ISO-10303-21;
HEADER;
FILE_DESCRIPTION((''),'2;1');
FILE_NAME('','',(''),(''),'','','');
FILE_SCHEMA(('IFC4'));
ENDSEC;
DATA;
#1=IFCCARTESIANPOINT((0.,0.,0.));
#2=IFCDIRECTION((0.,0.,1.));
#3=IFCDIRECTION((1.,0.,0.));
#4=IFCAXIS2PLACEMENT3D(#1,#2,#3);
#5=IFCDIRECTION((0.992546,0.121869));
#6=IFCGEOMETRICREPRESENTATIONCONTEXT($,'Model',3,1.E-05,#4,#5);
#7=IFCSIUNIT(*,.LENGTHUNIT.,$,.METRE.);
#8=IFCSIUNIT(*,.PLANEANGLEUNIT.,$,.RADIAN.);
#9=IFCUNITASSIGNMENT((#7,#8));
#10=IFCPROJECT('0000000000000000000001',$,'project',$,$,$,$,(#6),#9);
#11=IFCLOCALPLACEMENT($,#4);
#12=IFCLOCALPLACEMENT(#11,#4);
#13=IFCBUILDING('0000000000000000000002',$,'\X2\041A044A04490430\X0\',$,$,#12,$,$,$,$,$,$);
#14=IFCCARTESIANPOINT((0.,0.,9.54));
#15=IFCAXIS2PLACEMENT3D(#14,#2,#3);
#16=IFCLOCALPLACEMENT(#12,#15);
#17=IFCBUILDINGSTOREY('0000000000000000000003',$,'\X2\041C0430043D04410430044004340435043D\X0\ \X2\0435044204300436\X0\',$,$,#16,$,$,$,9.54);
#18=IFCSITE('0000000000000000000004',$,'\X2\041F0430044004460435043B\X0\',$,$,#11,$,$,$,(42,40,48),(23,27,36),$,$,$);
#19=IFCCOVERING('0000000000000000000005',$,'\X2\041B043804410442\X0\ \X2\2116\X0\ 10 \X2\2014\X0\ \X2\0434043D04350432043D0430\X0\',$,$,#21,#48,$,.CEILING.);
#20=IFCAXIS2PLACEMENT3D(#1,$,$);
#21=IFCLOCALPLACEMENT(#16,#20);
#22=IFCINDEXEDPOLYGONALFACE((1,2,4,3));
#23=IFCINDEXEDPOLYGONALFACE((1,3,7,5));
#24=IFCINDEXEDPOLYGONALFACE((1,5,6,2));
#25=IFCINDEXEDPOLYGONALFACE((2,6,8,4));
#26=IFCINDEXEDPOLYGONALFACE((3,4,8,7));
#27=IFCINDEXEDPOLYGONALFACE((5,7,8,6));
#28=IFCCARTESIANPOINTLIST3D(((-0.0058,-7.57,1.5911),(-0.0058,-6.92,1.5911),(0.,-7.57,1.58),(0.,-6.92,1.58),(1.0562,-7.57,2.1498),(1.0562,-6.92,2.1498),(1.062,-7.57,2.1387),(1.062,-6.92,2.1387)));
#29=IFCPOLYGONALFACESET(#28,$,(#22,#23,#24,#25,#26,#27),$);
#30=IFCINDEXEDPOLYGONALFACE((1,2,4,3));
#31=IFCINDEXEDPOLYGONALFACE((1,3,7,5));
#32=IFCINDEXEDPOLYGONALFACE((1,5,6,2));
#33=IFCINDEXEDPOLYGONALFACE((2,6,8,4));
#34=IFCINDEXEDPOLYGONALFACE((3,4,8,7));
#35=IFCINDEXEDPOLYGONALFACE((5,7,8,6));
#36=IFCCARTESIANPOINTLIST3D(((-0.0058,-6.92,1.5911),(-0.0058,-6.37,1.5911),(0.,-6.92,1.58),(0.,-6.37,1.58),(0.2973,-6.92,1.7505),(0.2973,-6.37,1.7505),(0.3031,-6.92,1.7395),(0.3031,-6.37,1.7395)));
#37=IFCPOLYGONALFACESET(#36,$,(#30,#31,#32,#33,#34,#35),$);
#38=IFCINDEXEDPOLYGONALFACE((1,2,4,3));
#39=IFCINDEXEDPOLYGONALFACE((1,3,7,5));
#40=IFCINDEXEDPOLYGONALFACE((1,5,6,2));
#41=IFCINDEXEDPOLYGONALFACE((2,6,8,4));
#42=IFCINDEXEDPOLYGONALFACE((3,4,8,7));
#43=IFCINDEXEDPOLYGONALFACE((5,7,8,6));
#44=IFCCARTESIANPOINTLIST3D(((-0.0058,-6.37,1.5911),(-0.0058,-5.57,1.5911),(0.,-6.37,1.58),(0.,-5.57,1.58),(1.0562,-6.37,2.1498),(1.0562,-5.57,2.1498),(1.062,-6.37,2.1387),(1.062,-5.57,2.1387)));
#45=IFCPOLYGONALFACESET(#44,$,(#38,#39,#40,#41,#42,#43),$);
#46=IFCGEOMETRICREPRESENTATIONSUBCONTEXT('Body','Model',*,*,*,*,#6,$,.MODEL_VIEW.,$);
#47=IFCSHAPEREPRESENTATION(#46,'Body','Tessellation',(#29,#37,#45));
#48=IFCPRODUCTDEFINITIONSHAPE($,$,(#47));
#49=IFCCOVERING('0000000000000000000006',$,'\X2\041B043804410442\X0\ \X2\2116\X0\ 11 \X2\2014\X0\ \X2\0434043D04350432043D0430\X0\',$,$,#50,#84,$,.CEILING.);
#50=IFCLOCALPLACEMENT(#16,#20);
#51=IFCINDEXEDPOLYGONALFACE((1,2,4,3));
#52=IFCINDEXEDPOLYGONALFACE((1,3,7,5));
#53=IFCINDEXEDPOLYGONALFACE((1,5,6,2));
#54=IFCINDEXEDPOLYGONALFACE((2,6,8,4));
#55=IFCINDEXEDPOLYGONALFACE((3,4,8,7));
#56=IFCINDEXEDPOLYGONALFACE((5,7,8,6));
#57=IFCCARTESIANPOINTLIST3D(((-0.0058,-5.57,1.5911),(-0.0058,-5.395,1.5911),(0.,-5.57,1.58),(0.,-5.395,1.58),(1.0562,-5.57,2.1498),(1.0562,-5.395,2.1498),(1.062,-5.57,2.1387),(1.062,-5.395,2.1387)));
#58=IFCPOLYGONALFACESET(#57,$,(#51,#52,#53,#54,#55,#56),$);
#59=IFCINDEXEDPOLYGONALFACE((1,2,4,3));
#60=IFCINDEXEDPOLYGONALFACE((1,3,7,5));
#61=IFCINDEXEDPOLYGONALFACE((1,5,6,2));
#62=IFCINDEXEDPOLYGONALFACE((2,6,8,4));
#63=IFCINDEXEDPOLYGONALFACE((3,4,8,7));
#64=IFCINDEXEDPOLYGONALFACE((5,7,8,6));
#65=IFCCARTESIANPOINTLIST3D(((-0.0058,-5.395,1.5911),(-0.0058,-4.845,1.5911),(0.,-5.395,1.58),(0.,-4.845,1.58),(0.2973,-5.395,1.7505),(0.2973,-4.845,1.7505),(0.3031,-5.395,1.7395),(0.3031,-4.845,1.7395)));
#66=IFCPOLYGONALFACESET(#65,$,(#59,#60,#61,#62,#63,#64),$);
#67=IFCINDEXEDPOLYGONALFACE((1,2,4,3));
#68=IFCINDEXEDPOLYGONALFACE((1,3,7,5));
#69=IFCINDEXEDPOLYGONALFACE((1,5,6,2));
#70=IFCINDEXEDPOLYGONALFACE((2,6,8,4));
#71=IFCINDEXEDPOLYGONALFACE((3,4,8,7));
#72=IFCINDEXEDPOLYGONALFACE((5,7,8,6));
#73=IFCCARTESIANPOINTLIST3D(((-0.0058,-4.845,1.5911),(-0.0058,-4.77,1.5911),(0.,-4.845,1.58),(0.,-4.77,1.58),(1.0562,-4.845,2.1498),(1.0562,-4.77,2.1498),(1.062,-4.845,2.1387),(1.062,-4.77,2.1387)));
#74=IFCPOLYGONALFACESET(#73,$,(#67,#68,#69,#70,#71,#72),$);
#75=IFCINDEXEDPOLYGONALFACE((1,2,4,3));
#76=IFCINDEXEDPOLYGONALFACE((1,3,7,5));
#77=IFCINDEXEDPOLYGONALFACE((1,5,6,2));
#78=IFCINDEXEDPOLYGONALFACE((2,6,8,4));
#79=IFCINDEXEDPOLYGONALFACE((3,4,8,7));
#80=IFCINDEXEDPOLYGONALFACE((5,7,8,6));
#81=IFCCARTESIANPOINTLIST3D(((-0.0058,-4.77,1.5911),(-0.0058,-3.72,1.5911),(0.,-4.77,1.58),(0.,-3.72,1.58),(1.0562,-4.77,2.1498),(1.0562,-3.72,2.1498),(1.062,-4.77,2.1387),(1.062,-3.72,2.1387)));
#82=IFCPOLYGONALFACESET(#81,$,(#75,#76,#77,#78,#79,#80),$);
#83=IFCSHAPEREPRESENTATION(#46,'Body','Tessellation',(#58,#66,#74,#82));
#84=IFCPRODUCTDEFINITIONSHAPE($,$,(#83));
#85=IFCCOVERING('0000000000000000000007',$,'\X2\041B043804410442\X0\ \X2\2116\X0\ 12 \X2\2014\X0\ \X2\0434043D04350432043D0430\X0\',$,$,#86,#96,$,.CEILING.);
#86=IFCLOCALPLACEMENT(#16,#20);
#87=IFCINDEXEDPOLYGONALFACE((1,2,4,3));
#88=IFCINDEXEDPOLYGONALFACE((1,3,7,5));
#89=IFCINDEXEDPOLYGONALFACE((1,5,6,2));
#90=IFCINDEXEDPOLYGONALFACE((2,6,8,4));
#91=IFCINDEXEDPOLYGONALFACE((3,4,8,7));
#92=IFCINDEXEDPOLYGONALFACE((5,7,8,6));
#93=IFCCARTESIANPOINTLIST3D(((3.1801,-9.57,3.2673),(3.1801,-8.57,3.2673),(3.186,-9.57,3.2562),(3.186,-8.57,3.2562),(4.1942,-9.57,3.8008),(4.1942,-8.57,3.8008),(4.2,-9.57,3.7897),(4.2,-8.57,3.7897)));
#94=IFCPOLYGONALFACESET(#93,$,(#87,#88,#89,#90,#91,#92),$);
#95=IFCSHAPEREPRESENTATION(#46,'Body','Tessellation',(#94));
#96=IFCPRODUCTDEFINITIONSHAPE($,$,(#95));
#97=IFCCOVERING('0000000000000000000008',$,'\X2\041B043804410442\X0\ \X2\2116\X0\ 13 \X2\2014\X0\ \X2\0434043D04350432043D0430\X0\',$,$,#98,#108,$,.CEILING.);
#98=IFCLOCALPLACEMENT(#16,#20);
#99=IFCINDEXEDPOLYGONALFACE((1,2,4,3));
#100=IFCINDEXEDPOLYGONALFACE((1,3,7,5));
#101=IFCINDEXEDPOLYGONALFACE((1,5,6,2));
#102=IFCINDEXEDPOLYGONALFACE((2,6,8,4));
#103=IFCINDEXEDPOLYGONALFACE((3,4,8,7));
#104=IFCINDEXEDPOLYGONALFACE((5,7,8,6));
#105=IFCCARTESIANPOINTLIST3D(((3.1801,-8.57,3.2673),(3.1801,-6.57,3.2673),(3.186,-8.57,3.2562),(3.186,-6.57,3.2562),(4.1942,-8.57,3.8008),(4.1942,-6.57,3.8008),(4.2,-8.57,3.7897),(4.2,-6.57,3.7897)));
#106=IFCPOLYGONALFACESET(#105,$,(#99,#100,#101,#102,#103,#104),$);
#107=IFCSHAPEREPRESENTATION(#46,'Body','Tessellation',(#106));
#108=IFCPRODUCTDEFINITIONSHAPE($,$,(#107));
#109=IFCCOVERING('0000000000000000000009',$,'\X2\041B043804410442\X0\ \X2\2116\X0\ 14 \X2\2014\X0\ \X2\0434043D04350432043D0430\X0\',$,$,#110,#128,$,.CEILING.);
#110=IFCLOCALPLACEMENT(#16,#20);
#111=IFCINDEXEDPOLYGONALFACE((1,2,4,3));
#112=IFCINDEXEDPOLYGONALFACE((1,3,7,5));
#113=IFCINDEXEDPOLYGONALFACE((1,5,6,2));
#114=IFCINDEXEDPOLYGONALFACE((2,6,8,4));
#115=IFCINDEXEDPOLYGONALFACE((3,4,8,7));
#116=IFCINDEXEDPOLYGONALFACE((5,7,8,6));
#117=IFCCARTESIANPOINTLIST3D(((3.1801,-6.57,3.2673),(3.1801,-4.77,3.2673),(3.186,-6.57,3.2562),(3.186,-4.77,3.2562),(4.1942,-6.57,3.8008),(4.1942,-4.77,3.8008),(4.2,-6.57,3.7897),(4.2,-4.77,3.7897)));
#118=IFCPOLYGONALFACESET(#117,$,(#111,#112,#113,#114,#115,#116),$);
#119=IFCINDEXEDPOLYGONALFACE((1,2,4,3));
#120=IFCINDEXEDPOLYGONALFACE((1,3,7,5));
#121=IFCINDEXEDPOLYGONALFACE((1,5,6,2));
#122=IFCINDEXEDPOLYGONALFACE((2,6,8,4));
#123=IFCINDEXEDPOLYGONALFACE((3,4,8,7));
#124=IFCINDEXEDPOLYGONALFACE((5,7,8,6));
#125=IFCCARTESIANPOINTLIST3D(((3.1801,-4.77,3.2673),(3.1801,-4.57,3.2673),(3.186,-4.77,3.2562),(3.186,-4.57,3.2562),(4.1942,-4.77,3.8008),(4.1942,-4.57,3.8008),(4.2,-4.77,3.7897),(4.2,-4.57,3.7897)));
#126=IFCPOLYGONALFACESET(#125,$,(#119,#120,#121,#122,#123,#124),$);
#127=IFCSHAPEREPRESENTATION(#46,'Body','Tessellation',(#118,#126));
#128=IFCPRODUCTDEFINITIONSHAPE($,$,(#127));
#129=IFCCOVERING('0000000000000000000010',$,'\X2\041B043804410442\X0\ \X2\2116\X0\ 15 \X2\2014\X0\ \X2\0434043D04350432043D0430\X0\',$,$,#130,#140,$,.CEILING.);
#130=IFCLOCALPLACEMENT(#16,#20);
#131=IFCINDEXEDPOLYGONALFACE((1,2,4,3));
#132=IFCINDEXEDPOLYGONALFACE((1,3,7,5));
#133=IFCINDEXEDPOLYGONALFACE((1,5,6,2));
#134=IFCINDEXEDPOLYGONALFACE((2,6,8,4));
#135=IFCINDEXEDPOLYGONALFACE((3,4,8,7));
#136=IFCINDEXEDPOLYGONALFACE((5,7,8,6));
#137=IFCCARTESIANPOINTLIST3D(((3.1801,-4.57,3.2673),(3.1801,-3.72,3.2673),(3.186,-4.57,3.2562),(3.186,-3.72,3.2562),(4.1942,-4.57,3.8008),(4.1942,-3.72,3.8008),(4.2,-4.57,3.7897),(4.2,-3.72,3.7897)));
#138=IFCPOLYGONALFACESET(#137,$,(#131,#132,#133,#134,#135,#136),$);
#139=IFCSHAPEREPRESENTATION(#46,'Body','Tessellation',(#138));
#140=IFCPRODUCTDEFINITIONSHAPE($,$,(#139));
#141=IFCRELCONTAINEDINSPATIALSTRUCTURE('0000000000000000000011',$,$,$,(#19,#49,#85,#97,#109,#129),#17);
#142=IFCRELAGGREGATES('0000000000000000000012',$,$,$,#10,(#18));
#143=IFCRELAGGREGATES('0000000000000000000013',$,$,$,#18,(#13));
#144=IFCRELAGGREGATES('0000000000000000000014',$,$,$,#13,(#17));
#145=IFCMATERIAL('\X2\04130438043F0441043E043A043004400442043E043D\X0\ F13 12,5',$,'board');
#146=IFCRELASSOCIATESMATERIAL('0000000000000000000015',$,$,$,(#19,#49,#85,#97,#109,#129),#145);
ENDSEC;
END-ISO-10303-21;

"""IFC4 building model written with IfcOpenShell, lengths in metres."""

from ifc_helpers import new_model, si_unit, direction, frame, origin_with_axes, place, context, subcontext, project, spatial, polyline, outline, extrude, material, element, save


model = new_model("IFC4")

# Units and contexts
model_context = context("Model", 3, precision=1e-05, world=origin_with_axes(), true_north=direction((0.992546, 0.121869)))
body_context = subcontext(model_context, "Body", "Model", "MODEL_VIEW")
ifc_project = project(units=[si_unit("LENGTHUNIT", "METRE"), si_unit("PLANEANGLEUNIT", "RADIAN")], contexts=[model_context])

# Site, building, storey
site_placement = place(None, origin_with_axes())
site = spatial("IfcSite", under=ifc_project, at=site_placement, Name="Парцел", RefLatitude=(42, 40, 48), RefLongitude=(23, 27, 36))
building_placement = place(site_placement, origin_with_axes())
building = spatial("IfcBuilding", under=site, at=building_placement, Name="Къща")
storey_placement = place(building_placement, frame((0.0, 0.0, 9.54), z_axis=(0.0, 0.0, 1.0), x_axis=(1.0, 0.0, 0.0)))
storey = spatial("IfcBuildingStorey", under=building, at=storey_placement, Name="Мансарден етаж", Elevation=9.54)

# Coverings
ifc_material_1 = material(Name="Гипсокартон F13 12,5", Category="board")
covering_1_placement = place(storey_placement, origin_with_axes())
element("IfcCovering", 1, at=covering_1_placement, inside=storey, material=ifc_material_1, Name="Лист № 10 — дневна", PredefinedType="CEILING", context=body_context, shape_type="SweptSolid", body=[
    extrude(outline(polyline([(0.0, -1.58), (1.062, -2.1387), (1.0562, -2.1498), (-0.0058, -1.5911), (0.0, -1.58)])), frame((0.0, -7.57, 0.0), z_axis=(0.0, 1.0, 0.0), x_axis=(1.0, 0.0, 0.0)), (0.0, 0.0, 1.0), 0.65),
    extrude(outline(polyline([(0.0, -1.58), (0.3031, -1.7395), (0.2973, -1.7505), (-0.0058, -1.5911), (0.0, -1.58)])), frame((0.0, -6.92, 0.0), z_axis=(0.0, 1.0, 0.0), x_axis=(1.0, 0.0, 0.0)), (0.0, 0.0, 1.0), 0.55),
    extrude(outline(polyline([(0.0, -1.58), (1.062, -2.1387), (1.0562, -2.1498), (-0.0058, -1.5911), (0.0, -1.58)])), frame((0.0, -6.37, 0.0), z_axis=(0.0, 1.0, 0.0), x_axis=(1.0, 0.0, 0.0)), (0.0, 0.0, 1.0), 0.8),
])
covering_2_placement = place(storey_placement, origin_with_axes())
element("IfcCovering", 2, at=covering_2_placement, inside=storey, material=ifc_material_1, Name="Лист № 11 — дневна", PredefinedType="CEILING", context=body_context, shape_type="SweptSolid", body=[
    extrude(outline(polyline([(0.0, -1.58), (1.062, -2.1387), (1.0562, -2.1498), (-0.0058, -1.5911), (0.0, -1.58)])), frame((0.0, -5.57, 0.0), z_axis=(0.0, 1.0, 0.0), x_axis=(1.0, 0.0, 0.0)), (0.0, 0.0, 1.0), 0.175),
    extrude(outline(polyline([(0.0, -1.58), (0.3031, -1.7395), (0.2973, -1.7505), (-0.0058, -1.5911), (0.0, -1.58)])), frame((0.0, -5.395, 0.0), z_axis=(0.0, 1.0, 0.0), x_axis=(1.0, 0.0, 0.0)), (0.0, 0.0, 1.0), 0.55),
    extrude(outline(polyline([(0.0, -1.58), (1.062, -2.1387), (1.0562, -2.1498), (-0.0058, -1.5911), (0.0, -1.58)])), frame((0.0, -4.845, 0.0), z_axis=(0.0, 1.0, 0.0), x_axis=(1.0, 0.0, 0.0)), (0.0, 0.0, 1.0), 0.075),
    extrude(outline(polyline([(0.0, -1.58), (1.062, -2.1387), (1.0562, -2.1498), (-0.0058, -1.5911), (0.0, -1.58)])), frame((0.0, -4.77, 0.0), z_axis=(0.0, 1.0, 0.0), x_axis=(1.0, 0.0, 0.0)), (0.0, 0.0, 1.0), 1.05),
])
covering_3_placement = place(storey_placement, origin_with_axes())
element("IfcCovering", 3, at=covering_3_placement, inside=storey, material=ifc_material_1, Name="Лист № 12 — дневна", PredefinedType="CEILING", context=body_context, shape_type="SweptSolid", body=[
    extrude(outline(polyline([(3.186, -3.2562), (4.2, -3.7897), (4.1942, -3.8008), (3.1801, -3.2673), (3.186, -3.2562)])), frame((0.0, -9.57, 0.0), z_axis=(0.0, 1.0, 0.0), x_axis=(1.0, 0.0, 0.0)), (0.0, 0.0, 1.0), 1.0),
])
covering_4_placement = place(storey_placement, origin_with_axes())
element("IfcCovering", 4, at=covering_4_placement, inside=storey, material=ifc_material_1, Name="Лист № 13 — дневна", PredefinedType="CEILING", context=body_context, shape_type="SweptSolid", body=[
    extrude(outline(polyline([(3.186, -3.2562), (4.2, -3.7897), (4.1942, -3.8008), (3.1801, -3.2673), (3.186, -3.2562)])), frame((0.0, -8.57, 0.0), z_axis=(0.0, 1.0, 0.0), x_axis=(1.0, 0.0, 0.0)), (0.0, 0.0, 1.0), 2.0),
])
covering_5_placement = place(storey_placement, origin_with_axes())
element("IfcCovering", 5, at=covering_5_placement, inside=storey, material=ifc_material_1, Name="Лист № 14 — дневна", PredefinedType="CEILING", context=body_context, shape_type="SweptSolid", body=[
    extrude(outline(polyline([(3.186, -3.2562), (4.2, -3.7897), (4.1942, -3.8008), (3.1801, -3.2673), (3.186, -3.2562)])), frame((0.0, -6.57, 0.0), z_axis=(0.0, 1.0, 0.0), x_axis=(1.0, 0.0, 0.0)), (0.0, 0.0, 1.0), 1.8),
    extrude(outline(polyline([(3.186, -3.2562), (4.2, -3.7897), (4.1942, -3.8008), (3.1801, -3.2673), (3.186, -3.2562)])), frame((0.0, -4.77, 0.0), z_axis=(0.0, 1.0, 0.0), x_axis=(1.0, 0.0, 0.0)), (0.0, 0.0, 1.0), 0.2),
])
covering_6_placement = place(storey_placement, origin_with_axes())
element("IfcCovering", 6, at=covering_6_placement, inside=storey, material=ifc_material_1, Name="Лист № 15 — дневна", PredefinedType="CEILING", context=body_context, shape_type="SweptSolid", body=[
    extrude(outline(polyline([(3.186, -3.2562), (4.2, -3.7897), (4.1942, -3.8008), (3.1801, -3.2673), (3.186, -3.2562)])), frame((0.0, -4.57, 0.0), z_axis=(0.0, 1.0, 0.0), x_axis=(1.0, 0.0, 0.0)), (0.0, 0.0, 1.0), 0.85),
])

save(model, "model.ifc")
